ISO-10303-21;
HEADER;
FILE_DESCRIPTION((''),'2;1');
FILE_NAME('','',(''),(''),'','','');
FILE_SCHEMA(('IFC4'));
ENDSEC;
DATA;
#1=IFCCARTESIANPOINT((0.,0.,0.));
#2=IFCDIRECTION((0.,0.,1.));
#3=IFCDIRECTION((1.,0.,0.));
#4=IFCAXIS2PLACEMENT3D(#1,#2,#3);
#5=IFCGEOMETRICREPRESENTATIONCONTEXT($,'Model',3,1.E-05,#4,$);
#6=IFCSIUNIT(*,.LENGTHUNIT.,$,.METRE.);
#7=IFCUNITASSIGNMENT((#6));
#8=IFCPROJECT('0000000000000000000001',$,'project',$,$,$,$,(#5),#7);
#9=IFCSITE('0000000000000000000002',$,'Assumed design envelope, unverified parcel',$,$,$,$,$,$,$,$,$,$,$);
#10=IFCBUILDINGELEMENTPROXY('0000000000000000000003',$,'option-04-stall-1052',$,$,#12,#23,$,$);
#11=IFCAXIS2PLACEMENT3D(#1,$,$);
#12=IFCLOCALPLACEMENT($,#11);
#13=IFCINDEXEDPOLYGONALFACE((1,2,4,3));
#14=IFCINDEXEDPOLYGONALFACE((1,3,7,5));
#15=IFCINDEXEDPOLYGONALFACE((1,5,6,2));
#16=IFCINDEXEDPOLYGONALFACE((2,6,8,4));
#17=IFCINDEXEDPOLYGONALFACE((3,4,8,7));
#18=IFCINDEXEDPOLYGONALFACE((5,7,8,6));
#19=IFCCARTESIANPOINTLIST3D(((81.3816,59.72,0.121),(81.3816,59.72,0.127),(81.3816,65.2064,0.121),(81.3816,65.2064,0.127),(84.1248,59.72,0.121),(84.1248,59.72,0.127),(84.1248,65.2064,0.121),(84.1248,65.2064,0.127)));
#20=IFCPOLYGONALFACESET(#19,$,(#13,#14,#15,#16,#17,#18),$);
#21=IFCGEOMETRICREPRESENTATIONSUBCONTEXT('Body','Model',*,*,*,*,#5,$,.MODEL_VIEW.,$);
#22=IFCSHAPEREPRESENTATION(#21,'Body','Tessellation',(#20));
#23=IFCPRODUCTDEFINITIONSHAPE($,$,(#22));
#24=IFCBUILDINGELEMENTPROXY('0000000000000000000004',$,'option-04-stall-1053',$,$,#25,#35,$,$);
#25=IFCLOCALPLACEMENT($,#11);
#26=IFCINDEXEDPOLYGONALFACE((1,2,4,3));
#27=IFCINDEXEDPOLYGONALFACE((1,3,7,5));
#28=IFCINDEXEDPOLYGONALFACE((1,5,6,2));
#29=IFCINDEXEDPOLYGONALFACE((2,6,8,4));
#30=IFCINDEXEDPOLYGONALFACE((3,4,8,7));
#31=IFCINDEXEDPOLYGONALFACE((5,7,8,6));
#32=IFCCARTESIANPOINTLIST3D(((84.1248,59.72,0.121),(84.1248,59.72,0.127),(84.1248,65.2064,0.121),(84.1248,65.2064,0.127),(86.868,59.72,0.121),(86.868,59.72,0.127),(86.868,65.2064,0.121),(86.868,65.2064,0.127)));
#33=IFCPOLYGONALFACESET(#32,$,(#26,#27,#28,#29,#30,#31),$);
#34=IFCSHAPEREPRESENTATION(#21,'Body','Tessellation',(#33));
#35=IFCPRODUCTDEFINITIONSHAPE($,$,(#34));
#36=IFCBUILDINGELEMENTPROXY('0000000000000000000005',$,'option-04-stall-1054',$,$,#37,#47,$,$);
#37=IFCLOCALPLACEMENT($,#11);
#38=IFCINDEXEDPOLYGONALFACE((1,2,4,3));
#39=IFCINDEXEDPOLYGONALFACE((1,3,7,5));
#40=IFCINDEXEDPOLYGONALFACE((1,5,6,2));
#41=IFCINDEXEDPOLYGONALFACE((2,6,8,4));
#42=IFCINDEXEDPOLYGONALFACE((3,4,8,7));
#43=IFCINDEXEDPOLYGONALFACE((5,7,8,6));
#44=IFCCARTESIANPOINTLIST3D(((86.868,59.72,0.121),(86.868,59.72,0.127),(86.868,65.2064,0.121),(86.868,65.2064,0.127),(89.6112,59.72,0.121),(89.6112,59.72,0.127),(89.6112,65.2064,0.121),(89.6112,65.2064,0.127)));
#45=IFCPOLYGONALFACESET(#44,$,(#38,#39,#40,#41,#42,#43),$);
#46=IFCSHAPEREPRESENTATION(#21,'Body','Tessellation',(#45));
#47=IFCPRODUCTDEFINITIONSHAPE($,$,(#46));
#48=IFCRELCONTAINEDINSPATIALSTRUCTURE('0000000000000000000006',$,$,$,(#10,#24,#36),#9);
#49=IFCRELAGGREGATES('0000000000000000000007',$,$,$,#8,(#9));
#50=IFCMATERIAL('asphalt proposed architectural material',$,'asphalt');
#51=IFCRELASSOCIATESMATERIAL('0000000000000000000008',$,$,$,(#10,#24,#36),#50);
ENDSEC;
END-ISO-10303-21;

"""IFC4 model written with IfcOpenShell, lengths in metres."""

from ifc_helpers import new_model, si_unit, frame, origin_with_axes, place, context, subcontext, project, spatial, rectangle, extrude, material, element, save


model = new_model("IFC4")

# Units and contexts
model_context = context("Model", 3, precision=1e-05, world=origin_with_axes())
body_context = subcontext(model_context, "Body", "Model", "MODEL_VIEW")
ifc_project = project(units=[si_unit("LENGTHUNIT", "METRE")], contexts=[model_context])

# Site
site = spatial("IfcSite", under=ifc_project, Name="Assumed design envelope, unverified parcel")

# Building element proxies
ifc_material = material(Name="asphalt proposed architectural material", Category="asphalt")
for number, where, z_axis, x_axis, name in (
    (1, (82.7532, 62.4632, 0.121), (0.0, 0.0, 1.0), (1.0, 0.0, 0.0), "option-04-stall-1052"),
    (2, (85.4964, 62.4632, 0.121), (0.0, 0.0, 1.0), (1.0, 0.0, 0.0), "option-04-stall-1053"),
    (3, (88.2396, 62.4632, 0.121), (0.0, 0.0, 1.0), (1.0, 0.0, 0.0), "option-04-stall-1054"),
):
    element("IfcBuildingElementProxy", number, at=place(None, frame(where, z_axis=z_axis, x_axis=x_axis)), inside=site, material=ifc_material, Name=name, context=body_context, shape_type="SweptSolid", body=[
        extrude(rectangle(XDim=2.7432, YDim=5.4864), origin_with_axes(), (0.0, 0.0, 1.0), 0.006),
    ])

save(model, "model.ifc")
